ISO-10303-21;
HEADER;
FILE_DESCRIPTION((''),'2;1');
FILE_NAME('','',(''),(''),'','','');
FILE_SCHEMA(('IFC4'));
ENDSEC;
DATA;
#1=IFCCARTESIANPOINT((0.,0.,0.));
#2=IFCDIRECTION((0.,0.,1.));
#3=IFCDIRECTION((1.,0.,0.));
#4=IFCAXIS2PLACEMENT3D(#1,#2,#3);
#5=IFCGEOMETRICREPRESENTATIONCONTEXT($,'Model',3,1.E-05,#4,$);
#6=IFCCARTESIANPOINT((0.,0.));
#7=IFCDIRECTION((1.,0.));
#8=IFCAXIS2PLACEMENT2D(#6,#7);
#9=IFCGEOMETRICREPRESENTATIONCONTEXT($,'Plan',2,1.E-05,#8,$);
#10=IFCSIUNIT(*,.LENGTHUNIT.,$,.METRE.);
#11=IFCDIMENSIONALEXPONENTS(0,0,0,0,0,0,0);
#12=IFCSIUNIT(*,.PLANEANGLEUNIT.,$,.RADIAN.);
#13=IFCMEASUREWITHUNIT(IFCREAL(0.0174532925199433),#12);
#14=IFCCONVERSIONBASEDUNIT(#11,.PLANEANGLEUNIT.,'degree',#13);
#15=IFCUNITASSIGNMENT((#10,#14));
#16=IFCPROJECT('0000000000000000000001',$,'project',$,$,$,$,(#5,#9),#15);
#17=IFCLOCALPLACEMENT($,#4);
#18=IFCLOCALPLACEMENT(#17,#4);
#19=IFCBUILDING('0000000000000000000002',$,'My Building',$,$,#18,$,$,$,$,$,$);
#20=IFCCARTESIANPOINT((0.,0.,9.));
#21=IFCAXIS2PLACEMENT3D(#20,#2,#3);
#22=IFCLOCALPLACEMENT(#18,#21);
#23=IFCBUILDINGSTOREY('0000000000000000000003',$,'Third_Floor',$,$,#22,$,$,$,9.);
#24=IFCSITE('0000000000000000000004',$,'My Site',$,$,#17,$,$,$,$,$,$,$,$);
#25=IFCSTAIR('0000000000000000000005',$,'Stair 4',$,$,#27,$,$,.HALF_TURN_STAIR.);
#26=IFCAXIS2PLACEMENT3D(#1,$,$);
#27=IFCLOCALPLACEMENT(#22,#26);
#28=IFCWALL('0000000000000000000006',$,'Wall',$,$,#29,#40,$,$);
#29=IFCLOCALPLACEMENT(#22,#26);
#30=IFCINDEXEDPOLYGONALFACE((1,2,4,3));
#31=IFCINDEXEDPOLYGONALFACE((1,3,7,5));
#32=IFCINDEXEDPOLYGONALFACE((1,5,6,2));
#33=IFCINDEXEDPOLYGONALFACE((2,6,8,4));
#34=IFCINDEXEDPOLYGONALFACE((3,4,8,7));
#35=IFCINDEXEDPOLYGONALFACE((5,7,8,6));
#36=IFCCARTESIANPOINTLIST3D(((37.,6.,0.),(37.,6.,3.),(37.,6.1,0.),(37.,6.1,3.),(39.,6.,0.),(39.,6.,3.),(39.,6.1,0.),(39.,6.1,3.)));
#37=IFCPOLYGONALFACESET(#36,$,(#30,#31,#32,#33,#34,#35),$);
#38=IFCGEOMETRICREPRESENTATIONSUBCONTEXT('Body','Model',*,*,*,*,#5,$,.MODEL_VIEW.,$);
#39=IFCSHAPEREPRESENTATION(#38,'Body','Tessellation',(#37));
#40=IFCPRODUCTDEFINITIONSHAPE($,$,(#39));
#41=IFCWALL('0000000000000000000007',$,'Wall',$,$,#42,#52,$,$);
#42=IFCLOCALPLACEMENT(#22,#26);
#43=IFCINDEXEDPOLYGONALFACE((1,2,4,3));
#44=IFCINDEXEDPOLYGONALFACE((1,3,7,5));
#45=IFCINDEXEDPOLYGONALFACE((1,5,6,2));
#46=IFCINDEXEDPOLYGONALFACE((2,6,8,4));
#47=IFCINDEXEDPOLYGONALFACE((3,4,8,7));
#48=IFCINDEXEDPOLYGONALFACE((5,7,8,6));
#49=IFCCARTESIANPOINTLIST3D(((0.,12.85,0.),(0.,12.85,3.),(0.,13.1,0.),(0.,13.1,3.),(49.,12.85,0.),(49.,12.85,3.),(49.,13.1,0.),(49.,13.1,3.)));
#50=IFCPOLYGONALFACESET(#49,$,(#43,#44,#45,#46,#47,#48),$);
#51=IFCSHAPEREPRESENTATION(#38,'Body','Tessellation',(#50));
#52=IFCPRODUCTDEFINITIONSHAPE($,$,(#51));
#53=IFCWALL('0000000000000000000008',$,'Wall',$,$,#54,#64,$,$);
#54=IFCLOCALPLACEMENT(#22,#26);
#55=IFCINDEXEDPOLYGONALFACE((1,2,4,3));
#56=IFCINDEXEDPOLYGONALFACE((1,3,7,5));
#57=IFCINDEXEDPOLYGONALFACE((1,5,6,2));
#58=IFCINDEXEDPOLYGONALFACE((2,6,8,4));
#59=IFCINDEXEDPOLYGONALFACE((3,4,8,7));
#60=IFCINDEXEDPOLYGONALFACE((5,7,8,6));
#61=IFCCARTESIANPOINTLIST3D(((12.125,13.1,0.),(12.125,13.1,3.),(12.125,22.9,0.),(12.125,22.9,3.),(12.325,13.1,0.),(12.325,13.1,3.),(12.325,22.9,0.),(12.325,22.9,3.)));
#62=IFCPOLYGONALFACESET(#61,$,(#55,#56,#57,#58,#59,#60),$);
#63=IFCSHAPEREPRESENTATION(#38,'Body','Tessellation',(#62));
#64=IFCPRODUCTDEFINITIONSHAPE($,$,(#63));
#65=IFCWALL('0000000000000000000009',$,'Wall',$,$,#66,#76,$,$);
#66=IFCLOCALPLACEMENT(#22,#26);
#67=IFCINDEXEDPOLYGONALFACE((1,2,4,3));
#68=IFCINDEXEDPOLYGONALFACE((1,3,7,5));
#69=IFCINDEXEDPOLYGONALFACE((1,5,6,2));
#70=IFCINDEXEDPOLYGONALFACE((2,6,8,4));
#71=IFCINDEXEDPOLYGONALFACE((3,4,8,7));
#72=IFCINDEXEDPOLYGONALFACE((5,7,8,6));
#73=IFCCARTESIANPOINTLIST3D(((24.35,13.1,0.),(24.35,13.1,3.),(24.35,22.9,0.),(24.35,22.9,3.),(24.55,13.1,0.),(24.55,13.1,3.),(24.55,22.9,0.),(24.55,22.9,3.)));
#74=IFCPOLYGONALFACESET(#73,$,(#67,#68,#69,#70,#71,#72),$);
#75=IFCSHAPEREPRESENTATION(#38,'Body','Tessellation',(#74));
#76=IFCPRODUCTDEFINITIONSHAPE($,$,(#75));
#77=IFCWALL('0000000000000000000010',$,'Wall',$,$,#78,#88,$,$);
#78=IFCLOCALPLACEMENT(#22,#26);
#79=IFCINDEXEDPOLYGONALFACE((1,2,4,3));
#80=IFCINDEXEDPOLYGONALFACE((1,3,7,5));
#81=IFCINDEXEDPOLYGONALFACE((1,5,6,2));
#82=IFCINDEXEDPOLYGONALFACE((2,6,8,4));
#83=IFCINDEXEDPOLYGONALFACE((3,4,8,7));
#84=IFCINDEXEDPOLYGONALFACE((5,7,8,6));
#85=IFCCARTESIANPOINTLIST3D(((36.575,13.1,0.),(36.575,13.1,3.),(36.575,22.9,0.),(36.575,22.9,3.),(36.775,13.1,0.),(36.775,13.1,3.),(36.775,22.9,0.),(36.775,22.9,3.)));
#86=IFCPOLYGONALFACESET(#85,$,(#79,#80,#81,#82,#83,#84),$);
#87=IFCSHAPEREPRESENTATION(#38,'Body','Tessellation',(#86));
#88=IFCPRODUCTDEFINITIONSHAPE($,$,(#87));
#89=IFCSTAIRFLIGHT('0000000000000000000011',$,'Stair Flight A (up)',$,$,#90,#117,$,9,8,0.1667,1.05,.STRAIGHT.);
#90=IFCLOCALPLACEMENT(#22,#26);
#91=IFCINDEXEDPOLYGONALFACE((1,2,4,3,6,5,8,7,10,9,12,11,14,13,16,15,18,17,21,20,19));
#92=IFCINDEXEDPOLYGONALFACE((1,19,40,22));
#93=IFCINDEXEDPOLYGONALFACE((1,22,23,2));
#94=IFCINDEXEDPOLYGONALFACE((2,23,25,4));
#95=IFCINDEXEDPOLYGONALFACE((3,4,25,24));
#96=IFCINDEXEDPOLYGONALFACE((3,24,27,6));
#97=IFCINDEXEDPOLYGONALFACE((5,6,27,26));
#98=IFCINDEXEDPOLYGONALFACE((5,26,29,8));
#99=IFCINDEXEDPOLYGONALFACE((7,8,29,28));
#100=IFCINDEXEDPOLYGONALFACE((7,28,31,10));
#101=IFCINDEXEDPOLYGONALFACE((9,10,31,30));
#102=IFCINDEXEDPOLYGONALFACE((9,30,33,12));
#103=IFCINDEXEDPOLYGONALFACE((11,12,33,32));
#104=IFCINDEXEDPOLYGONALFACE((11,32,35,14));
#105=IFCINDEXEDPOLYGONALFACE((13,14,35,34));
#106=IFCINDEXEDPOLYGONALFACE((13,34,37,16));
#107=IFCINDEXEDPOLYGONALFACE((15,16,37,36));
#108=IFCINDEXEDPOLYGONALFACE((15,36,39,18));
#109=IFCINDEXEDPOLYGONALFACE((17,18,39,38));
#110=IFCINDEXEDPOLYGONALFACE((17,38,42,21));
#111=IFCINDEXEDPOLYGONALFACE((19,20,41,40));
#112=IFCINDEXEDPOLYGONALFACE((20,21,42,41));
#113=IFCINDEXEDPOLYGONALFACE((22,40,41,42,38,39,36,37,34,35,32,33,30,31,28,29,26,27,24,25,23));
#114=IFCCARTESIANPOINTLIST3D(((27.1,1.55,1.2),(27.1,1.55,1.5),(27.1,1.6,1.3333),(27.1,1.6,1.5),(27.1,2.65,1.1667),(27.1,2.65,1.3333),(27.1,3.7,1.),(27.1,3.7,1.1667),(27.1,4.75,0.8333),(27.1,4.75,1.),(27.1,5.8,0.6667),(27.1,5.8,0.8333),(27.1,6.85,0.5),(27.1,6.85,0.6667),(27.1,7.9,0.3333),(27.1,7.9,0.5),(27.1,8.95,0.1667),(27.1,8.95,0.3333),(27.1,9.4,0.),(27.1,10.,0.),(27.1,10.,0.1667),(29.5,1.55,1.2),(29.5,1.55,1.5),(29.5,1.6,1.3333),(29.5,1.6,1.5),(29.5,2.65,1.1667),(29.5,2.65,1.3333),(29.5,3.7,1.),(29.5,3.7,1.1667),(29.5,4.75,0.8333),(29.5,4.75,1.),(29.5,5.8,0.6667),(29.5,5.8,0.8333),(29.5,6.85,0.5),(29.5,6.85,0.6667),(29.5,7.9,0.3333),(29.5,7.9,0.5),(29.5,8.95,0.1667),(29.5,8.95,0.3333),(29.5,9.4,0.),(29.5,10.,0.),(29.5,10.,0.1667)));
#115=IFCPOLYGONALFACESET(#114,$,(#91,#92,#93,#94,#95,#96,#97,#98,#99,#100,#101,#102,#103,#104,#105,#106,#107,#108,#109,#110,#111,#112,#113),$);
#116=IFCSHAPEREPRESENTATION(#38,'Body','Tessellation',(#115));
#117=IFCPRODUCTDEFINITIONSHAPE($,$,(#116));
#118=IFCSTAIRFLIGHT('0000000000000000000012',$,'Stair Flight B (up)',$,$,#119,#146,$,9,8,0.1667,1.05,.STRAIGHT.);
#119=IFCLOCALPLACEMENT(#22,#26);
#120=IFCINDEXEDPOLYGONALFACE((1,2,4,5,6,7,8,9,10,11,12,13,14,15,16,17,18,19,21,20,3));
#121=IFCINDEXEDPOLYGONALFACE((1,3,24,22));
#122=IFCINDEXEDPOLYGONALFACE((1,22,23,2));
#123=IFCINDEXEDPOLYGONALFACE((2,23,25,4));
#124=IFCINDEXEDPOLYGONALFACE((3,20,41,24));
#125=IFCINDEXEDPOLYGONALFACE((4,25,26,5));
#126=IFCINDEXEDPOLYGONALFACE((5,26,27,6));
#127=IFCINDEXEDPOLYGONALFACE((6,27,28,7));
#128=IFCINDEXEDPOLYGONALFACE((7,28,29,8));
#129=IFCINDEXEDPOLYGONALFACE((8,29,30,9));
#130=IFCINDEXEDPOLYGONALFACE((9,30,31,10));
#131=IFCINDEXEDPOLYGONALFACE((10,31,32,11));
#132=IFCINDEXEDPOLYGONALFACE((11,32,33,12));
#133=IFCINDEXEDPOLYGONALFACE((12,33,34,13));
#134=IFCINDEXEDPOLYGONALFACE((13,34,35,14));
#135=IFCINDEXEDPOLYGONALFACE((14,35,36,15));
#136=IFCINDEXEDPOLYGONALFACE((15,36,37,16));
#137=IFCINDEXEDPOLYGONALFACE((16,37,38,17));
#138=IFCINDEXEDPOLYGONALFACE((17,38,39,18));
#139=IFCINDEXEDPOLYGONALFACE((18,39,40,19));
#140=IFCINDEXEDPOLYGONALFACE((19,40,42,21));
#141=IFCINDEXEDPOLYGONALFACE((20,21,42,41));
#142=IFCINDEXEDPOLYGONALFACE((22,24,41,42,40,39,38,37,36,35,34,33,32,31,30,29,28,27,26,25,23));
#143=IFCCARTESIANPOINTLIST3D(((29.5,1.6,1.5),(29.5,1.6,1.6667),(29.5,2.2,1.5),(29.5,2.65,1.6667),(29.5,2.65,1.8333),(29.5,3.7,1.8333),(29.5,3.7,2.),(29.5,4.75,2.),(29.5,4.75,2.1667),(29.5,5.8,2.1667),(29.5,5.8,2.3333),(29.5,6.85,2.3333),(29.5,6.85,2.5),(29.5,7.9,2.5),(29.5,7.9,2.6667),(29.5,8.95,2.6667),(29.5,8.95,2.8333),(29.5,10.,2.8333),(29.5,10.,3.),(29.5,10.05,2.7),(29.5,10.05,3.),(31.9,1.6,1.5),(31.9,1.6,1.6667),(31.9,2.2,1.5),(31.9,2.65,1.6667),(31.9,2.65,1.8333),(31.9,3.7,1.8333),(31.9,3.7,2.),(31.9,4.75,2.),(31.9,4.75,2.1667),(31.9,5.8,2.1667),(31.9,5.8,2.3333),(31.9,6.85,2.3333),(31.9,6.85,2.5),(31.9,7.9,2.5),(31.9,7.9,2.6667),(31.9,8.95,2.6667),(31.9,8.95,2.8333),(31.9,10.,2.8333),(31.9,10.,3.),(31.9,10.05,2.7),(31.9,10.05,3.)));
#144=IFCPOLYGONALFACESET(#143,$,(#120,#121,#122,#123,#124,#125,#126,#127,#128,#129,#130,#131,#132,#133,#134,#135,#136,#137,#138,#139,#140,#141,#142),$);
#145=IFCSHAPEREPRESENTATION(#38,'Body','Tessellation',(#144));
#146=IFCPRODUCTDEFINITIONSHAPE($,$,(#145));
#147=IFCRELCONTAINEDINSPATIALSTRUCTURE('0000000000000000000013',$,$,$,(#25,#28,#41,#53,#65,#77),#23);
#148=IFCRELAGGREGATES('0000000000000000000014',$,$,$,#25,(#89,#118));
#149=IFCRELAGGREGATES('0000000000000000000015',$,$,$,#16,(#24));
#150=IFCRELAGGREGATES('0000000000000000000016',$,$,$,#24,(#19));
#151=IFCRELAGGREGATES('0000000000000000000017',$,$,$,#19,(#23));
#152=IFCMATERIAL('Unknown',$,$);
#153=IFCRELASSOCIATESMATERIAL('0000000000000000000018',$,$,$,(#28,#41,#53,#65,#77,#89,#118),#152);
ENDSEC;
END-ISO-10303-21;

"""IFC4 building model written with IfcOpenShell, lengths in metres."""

from ifc_helpers import new_model, entity, si_unit, converted_unit, frame, frame_2d, origin, origin_with_axes, origin_2d_with_axis, place, context, subcontext, project, spatial, polyline, rectangle, outline, extrude, material, element, aggregate, save


model = new_model("IFC4")

# Units and contexts
model_context = context("Model", 3, precision=1e-05, world=origin_with_axes())
plan_context = context("Plan", 2, precision=1e-05, world=origin_2d_with_axis())
body_context = subcontext(model_context, "Body", "Model", "MODEL_VIEW")
ifc_project = project(units=[si_unit("LENGTHUNIT", "METRE"), converted_unit("PLANEANGLEUNIT", "degree", entity("IfcReal", 0.0174532925199433), si_unit("PLANEANGLEUNIT", "RADIAN"), dimensions=[0, 0, 0, 0, 0, 0, 0])], contexts=[model_context, plan_context])

# Site, building, storey
site_placement = place(None, origin_with_axes())
site = spatial("IfcSite", under=ifc_project, at=site_placement, Name="My Site")
building_placement = place(site_placement, origin_with_axes())
building = spatial("IfcBuilding", under=site, at=building_placement, Name="My Building")
storey_placement = place(building_placement, frame((0.0, 0.0, 9.0), z_axis=(0.0, 0.0, 1.0), x_axis=(1.0, 0.0, 0.0)))
storey = spatial("IfcBuildingStorey", under=building, at=storey_placement, Name="Third_Floor", Elevation=9.0)

# Shared definitions
ifc_material = material(Name="Unknown")

# Stair
stair_placement = place(storey_placement, origin_with_axes())
stair = element("IfcStair", 1, at=stair_placement, inside=storey, Name="Stair 4", PredefinedType="HALF_TURN_STAIR")

# Walls
wall_1_placement = place(storey_placement, origin_with_axes())
element("IfcWall", 2, at=wall_1_placement, inside=storey, material=ifc_material, Name="Wall", context=body_context, shape_type="SweptSolid", body=[
    extrude(rectangle(XDim=2.0, YDim=0.1, at=frame_2d((38.0, 6.05))), origin(), (0.0, 0.0, 1.0), 3.0),
])
wall_2_placement = place(storey_placement, origin_with_axes())
element("IfcWall", 3, at=wall_2_placement, inside=storey, material=ifc_material, Name="Wall", context=body_context, shape_type="SweptSolid", body=[
    extrude(rectangle(XDim=49.0, YDim=0.25, at=frame_2d((24.5, 12.975))), origin(), (0.0, 0.0, 1.0), 3.0),
])
wall_3_placement = place(storey_placement, origin_with_axes())
element("IfcWall", 4, at=wall_3_placement, inside=storey, material=ifc_material, Name="Wall", context=body_context, shape_type="SweptSolid", body=[
    extrude(rectangle(XDim=0.2, YDim=9.8, at=frame_2d((12.225, 18.0))), origin(), (0.0, 0.0, 1.0), 3.0),
])
wall_4_placement = place(storey_placement, origin_with_axes())
element("IfcWall", 5, at=wall_4_placement, inside=storey, material=ifc_material, Name="Wall", context=body_context, shape_type="SweptSolid", body=[
    extrude(rectangle(XDim=0.2, YDim=9.8, at=frame_2d((24.45, 18.0))), origin(), (0.0, 0.0, 1.0), 3.0),
])
wall_5_placement = place(storey_placement, origin_with_axes())
element("IfcWall", 6, at=wall_5_placement, inside=storey, material=ifc_material, Name="Wall", context=body_context, shape_type="SweptSolid", body=[
    extrude(rectangle(XDim=0.2, YDim=9.8, at=frame_2d((36.675, 18.0))), origin(), (0.0, 0.0, 1.0), 3.0),
])

# Stair flights
stair_flight_1_placement = place(stair_placement, origin_with_axes())
stair_flight_1 = element("IfcStairFlight", 7, at=stair_flight_1_placement, material=ifc_material, Name="Stair Flight A (up)", NumberOfRisers=9, NumberOfTreads=8, PredefinedType="STRAIGHT", RiserHeight=0.1667, TreadLength=1.05, context=body_context, shape_type="SweptSolid", body=[
    extrude(outline(polyline([(10.0, 0.0), (10.0, 0.1667), (8.95, 0.1667), (8.95, 0.3333), (7.9, 0.3333), (7.9, 0.3333), (7.9, 0.5), (6.85, 0.5), (6.85, 0.5), (6.85, 0.6667), (5.8, 0.6667), (5.8, 0.8333), (4.75, 0.8333), (4.75, 1.0), (3.7, 1.0), (3.7, 1.0), (3.7, 1.1667), (2.65, 1.1667), (2.65, 1.3333), (1.6, 1.3333), (1.6, 1.3333), (1.6, 1.5), (1.55, 1.5), (1.55, 1.2), (9.4, 0.0), (10.0, 0.0)])), frame((27.1, 0.0, 0.0), z_axis=(1.0, 0.0, 0.0), x_axis=(0.0, 1.0, 0.0)), (0.0, 0.0, 1.0), 2.4),
])
stair_flight_2_placement = place(stair_placement, origin_with_axes())
stair_flight_2 = element("IfcStairFlight", 8, at=stair_flight_2_placement, material=ifc_material, Name="Stair Flight B (up)", NumberOfRisers=9, NumberOfTreads=8, PredefinedType="STRAIGHT", RiserHeight=0.1667, TreadLength=1.05, context=body_context, shape_type="SweptSolid", body=[
    extrude(outline(polyline([(1.6, 1.5), (1.6, 1.6667), (2.65, 1.6667), (2.65, 1.8333), (3.7, 1.8333), (3.7, 1.8333), (3.7, 2.0), (4.75, 2.0), (4.75, 2.1667), (5.8, 2.1667), (5.8, 2.3333), (6.85, 2.3333), (6.85, 2.5), (7.9, 2.5), (7.9, 2.5), (7.9, 2.6667), (8.95, 2.6667), (8.95, 2.6667), (8.95, 2.8333), (10.0, 2.8333), (10.0, 3.0), (10.05, 3.0), (10.05, 2.7), (2.2, 1.5), (1.6, 1.5)])), frame((29.5, 0.0, 0.0), z_axis=(1.0, 0.0, 0.0), x_axis=(0.0, 1.0, 0.0)), (0.0, 0.0, 1.0), 2.4),
])
aggregate(stair, [stair_flight_1, stair_flight_2])

save(model, "model.ifc")
